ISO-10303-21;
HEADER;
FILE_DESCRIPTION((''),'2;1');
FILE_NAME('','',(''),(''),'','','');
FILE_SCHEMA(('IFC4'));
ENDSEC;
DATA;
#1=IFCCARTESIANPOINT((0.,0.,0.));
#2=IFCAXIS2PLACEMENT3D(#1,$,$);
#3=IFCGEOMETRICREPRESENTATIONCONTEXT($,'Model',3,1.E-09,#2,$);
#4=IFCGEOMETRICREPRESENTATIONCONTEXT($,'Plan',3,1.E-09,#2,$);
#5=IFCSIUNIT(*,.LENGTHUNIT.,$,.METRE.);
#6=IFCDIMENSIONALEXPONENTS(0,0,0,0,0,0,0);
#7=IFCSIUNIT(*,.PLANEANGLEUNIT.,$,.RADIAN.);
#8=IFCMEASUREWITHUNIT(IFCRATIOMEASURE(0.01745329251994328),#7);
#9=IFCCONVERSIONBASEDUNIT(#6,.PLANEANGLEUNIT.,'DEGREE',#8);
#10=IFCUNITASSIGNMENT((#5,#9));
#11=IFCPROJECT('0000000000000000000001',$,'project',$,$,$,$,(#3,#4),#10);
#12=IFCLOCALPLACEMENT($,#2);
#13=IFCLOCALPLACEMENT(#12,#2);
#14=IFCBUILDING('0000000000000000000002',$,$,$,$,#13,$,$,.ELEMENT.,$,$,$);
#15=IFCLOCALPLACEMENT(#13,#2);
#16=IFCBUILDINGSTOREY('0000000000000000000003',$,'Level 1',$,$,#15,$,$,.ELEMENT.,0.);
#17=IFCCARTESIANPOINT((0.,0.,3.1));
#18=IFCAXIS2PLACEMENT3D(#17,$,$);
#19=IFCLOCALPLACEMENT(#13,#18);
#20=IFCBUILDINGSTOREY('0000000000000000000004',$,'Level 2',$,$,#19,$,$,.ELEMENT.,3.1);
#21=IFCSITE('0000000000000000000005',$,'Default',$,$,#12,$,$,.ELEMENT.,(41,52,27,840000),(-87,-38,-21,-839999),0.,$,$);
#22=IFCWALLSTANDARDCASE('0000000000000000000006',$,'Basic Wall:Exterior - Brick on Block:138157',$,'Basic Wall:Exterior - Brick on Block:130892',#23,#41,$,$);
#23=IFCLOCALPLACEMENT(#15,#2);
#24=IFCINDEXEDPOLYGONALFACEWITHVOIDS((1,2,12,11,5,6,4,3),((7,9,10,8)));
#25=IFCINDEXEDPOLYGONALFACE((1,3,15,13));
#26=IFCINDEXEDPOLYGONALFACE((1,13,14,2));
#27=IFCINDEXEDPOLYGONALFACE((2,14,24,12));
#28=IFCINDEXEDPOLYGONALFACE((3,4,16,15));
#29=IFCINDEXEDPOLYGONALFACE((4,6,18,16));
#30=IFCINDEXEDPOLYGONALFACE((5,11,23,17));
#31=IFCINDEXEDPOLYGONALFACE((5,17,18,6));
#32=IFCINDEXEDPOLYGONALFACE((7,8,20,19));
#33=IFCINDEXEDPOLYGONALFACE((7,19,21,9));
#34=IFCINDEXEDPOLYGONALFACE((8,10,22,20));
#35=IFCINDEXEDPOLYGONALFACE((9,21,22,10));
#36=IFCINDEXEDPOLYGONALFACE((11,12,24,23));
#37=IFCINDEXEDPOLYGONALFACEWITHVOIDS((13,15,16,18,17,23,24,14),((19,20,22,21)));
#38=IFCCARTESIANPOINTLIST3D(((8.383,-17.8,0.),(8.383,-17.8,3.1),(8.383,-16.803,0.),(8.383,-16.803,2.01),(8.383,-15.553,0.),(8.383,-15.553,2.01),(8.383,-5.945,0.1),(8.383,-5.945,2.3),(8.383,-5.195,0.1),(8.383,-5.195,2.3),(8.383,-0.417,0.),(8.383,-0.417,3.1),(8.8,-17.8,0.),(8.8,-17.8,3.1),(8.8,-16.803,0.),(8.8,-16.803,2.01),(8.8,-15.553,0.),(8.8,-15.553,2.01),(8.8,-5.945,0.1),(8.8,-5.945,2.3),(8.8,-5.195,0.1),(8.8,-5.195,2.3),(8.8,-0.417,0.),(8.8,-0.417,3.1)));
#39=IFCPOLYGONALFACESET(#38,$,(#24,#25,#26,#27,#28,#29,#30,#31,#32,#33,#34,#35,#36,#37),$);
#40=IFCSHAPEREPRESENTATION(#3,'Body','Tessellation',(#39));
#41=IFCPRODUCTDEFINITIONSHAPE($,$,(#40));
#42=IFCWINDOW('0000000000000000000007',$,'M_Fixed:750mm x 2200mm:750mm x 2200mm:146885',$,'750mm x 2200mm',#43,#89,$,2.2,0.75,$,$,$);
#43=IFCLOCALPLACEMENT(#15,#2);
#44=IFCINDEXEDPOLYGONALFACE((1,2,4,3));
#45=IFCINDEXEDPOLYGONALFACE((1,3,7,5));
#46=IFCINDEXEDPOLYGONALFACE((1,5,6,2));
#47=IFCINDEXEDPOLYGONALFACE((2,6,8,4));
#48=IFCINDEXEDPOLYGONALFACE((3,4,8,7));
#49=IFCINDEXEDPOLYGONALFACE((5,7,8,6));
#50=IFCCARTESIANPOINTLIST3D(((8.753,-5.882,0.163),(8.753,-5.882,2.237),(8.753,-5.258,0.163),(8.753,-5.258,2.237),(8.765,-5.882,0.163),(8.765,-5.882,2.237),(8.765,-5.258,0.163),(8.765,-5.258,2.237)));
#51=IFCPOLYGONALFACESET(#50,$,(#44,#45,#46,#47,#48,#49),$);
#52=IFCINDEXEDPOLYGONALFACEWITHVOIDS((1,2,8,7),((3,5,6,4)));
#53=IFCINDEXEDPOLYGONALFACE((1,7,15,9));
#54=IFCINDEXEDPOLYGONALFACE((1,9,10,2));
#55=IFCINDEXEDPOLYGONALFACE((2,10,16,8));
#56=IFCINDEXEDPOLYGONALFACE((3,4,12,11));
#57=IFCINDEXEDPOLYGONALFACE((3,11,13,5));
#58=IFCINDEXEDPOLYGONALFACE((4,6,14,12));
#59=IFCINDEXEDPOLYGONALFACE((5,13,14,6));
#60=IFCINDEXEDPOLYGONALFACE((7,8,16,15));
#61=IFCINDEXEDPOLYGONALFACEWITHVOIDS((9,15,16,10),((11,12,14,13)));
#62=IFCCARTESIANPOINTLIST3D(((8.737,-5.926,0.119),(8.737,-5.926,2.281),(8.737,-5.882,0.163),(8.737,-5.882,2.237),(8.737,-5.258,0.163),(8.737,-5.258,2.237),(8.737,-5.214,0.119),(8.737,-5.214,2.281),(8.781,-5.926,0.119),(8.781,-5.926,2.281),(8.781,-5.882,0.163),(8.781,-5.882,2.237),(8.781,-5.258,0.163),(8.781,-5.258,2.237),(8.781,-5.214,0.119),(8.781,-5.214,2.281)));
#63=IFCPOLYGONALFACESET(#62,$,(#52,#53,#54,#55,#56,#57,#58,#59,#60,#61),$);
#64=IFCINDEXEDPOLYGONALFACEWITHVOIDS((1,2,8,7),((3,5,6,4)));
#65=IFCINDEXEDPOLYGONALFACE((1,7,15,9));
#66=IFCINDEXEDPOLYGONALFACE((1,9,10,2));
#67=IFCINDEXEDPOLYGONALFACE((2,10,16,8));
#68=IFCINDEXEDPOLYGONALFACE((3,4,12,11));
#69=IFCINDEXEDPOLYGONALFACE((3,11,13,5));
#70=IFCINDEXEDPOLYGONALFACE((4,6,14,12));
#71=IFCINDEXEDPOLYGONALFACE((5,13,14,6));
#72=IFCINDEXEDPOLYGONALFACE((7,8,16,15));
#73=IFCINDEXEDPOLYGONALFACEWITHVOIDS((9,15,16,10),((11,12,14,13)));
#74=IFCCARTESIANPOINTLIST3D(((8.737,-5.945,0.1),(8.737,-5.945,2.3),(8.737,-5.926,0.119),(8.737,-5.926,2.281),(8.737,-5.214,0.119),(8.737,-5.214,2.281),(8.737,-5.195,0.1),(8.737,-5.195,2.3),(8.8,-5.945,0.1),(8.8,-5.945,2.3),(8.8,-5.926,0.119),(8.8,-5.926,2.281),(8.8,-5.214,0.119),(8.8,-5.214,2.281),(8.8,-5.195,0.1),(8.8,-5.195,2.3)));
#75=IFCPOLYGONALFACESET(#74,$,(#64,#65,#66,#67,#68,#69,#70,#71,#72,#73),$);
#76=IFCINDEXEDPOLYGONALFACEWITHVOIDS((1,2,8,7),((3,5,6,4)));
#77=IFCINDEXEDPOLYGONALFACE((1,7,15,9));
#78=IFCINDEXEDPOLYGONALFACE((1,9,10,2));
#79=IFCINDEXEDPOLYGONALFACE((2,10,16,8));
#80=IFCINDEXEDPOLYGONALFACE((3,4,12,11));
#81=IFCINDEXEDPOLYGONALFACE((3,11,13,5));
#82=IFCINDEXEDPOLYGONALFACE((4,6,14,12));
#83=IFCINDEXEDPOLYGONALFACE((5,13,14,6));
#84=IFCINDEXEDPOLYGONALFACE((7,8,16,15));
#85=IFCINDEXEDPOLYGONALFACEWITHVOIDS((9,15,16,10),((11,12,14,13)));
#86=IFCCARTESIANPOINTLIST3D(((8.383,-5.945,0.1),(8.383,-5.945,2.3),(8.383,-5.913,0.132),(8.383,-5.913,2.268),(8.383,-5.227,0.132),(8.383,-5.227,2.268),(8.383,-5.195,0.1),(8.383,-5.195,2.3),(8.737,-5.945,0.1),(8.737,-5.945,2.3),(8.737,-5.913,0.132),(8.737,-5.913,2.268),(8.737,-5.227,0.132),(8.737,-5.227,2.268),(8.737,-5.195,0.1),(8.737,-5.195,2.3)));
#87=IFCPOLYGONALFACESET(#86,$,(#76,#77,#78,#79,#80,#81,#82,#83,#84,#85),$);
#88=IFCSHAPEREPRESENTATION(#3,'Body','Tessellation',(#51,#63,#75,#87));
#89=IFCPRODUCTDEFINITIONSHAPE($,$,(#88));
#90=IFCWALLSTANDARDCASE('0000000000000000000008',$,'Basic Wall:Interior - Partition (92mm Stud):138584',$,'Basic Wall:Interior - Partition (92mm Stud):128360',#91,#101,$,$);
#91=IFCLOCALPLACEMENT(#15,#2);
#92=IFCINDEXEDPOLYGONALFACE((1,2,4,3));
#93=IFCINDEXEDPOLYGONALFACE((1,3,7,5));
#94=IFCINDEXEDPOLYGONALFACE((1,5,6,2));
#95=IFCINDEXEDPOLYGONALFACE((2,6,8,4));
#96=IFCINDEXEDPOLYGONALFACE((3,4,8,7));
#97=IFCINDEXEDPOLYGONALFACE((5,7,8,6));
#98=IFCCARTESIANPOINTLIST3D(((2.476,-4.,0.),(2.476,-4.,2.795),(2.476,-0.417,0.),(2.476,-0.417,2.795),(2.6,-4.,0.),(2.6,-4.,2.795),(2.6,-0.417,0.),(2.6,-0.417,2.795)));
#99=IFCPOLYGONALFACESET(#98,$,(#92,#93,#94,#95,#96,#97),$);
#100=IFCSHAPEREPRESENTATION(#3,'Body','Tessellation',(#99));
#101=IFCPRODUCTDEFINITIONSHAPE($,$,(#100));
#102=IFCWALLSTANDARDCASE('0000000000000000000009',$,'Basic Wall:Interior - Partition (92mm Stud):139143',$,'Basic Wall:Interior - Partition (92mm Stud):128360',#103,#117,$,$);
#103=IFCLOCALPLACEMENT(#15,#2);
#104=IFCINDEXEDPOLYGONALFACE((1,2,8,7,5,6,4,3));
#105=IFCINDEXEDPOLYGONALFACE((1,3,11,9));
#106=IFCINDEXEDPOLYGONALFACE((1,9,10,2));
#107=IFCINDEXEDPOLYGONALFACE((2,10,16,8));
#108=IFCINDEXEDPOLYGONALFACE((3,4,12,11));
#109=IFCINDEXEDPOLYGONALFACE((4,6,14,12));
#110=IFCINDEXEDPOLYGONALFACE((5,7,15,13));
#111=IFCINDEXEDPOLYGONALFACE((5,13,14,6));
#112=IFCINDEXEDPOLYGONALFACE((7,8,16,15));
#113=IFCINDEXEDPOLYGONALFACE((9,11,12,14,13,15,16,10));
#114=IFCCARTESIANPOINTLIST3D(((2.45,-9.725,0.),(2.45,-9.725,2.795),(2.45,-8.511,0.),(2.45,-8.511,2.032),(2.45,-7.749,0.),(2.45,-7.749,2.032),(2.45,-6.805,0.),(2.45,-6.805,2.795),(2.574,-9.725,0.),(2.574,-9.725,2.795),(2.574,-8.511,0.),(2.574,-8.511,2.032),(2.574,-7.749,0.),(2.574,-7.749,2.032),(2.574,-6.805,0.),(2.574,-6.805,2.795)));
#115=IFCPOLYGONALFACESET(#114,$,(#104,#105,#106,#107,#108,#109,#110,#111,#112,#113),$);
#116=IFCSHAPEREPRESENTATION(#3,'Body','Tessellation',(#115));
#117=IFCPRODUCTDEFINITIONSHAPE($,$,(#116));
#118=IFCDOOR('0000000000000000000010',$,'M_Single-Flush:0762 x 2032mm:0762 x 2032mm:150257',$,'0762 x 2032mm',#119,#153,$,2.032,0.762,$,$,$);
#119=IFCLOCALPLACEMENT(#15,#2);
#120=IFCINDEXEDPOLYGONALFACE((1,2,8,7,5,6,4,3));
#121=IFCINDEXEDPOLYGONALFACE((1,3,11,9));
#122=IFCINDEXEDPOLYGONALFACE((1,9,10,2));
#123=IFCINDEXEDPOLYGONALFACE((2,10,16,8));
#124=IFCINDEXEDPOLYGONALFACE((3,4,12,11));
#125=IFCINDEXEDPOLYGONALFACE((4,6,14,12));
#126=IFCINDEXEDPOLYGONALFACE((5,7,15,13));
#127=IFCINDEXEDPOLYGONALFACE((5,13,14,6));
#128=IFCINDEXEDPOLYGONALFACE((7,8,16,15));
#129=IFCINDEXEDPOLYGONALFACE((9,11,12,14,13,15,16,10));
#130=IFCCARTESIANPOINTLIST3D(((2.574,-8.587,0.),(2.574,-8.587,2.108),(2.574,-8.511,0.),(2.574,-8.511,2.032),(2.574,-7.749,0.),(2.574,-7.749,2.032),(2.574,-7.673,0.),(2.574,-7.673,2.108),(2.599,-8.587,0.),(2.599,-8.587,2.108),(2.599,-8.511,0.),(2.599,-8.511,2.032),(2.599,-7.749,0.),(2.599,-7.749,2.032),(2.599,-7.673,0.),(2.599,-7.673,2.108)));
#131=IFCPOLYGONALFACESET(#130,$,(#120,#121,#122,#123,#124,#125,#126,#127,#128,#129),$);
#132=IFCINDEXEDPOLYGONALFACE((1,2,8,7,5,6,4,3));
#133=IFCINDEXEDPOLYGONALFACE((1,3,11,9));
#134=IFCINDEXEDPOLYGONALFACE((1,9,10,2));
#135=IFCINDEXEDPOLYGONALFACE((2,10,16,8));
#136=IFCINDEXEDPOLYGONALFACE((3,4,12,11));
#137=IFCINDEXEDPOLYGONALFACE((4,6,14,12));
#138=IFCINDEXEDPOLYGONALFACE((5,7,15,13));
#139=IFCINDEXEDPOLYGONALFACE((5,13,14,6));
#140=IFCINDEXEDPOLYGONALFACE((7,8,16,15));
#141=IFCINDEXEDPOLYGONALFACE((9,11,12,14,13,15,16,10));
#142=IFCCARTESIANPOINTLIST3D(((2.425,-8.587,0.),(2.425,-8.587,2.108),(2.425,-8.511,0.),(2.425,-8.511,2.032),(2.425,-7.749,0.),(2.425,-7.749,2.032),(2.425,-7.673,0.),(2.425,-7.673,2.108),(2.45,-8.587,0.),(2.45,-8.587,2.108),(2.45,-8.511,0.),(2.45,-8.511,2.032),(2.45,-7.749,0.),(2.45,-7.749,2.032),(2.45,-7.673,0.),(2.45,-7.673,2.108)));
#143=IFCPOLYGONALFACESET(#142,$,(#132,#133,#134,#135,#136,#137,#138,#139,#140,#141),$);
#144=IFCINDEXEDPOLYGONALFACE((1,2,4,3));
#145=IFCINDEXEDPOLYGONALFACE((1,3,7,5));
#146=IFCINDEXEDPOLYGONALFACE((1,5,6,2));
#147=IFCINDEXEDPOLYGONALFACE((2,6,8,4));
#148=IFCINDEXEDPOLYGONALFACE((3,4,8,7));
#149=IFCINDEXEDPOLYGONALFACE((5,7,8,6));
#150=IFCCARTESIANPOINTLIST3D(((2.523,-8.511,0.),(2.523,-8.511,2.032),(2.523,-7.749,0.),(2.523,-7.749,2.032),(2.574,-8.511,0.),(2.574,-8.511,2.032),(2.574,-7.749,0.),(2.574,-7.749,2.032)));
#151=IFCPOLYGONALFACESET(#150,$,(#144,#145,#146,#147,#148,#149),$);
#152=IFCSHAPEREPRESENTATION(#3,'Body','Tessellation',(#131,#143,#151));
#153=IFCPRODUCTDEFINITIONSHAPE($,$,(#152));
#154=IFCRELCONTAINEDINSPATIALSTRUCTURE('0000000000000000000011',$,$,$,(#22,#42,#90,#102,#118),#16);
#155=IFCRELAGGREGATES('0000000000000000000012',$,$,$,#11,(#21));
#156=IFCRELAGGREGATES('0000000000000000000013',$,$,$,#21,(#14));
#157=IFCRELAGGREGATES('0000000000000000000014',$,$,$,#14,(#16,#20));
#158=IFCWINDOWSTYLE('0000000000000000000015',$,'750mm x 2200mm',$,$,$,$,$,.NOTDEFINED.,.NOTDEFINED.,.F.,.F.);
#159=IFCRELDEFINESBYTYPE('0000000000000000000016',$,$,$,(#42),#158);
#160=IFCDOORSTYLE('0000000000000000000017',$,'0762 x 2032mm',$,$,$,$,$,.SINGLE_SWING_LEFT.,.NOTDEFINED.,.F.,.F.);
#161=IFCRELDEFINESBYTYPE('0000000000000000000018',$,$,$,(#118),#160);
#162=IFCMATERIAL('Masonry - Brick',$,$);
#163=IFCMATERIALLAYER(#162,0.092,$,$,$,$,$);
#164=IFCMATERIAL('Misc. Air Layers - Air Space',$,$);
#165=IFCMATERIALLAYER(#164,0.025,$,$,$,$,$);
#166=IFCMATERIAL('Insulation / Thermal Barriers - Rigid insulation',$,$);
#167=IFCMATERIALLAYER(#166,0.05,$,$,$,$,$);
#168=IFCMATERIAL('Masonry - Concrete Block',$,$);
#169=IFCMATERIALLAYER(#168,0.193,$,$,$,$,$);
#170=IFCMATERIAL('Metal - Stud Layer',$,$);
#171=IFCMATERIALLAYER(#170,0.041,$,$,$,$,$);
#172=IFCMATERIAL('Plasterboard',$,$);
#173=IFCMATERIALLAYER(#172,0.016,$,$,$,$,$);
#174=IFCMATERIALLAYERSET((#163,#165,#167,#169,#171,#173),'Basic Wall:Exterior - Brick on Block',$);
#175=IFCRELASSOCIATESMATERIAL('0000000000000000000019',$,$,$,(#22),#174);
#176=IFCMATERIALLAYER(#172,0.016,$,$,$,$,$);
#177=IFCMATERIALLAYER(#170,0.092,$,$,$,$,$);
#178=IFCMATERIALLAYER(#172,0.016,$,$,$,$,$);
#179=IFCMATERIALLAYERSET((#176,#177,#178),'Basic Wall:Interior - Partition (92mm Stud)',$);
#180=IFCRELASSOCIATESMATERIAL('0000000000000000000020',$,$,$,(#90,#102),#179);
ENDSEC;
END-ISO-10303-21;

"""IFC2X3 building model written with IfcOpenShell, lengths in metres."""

from ifc_helpers import new_model, entity, si_unit, converted_unit, frame, frame_2d, origin, origin_2d_with_axis, place, context, project, spatial, polyline, rectangle, outline, extrude, source, transform, mapped, material, layer, layer_set, layer_usage, type_object, type_shapes, element, fill, save


model = new_model("IFC2X3")

# Units and contexts
model_context_1 = context("Model", 3, precision=1e-09, world=origin())
plan_context = context("Plan", 3, precision=1e-09, world=origin())
ifc_project = project(units=[si_unit("LENGTHUNIT", "METRE"), converted_unit("PLANEANGLEUNIT", "DEGREE", entity("IfcRatioMeasure", 0.01745329251994328), si_unit("PLANEANGLEUNIT", "RADIAN"), dimensions=[0, 0, 0, 0, 0, 0, 0])], contexts=[model_context_1, plan_context])

# Site, building, storey
site_placement = place(None, origin())
site = spatial("IfcSite", under=ifc_project, at=site_placement, Name="Default", CompositionType="ELEMENT", RefLatitude=(41, 52, 27, 840000), RefLongitude=(-87, -38, -21, -839999), RefElevation=0.0)
building_placement = place(site_placement, origin())
building = spatial("IfcBuilding", under=site, at=building_placement, CompositionType="ELEMENT")
storey_1_placement = place(building_placement, origin())
storey_1 = spatial("IfcBuildingStorey", under=building, at=storey_1_placement, Name="Level 1", CompositionType="ELEMENT", Elevation=0.0)

# Shared definitions
ifc_material_1 = material(Name="Masonry - Brick")
ifc_layer_1 = layer(ifc_material_1, 0.092)
ifc_material_2 = material(Name="Misc. Air Layers - Air Space")
ifc_layer_2 = layer(ifc_material_2, 0.025)
ifc_material_3 = material(Name="Insulation / Thermal Barriers - Rigid insulation")
ifc_layer_3 = layer(ifc_material_3, 0.05)
ifc_material_4 = material(Name="Masonry - Concrete Block")
ifc_layer_4 = layer(ifc_material_4, 0.193)
ifc_material_5 = material(Name="Metal - Stud Layer")
ifc_layer_5 = layer(ifc_material_5, 0.041)
ifc_material_6 = material(Name="Plasterboard")
ifc_layer_6 = layer(ifc_material_6, 0.016)
ifc_layer_set_1 = layer_set([ifc_layer_1, ifc_layer_2, ifc_layer_3, ifc_layer_4, ifc_layer_5, ifc_layer_6], Name="Basic Wall:Exterior - Brick on Block")

# Wall, openings, window
ifc_layer_usage_1 = layer_usage(ifc_layer_set_1, "AXIS2", "NEGATIVE", 0.2085)
wall_1_placement = place(storey_1_placement, frame((8.5915, -0.417, 0.0), z_axis=(0.0, 0.0, 1.0), x_axis=(0.0, -1.0, 0.0)))
wall_1 = element("IfcWallStandardCase", 1, at=wall_1_placement, inside=storey_1, material=ifc_layer_usage_1, Name="Basic Wall:Exterior - Brick on Block:138157", ObjectType="Basic Wall:Exterior - Brick on Block:130892", context=model_context_1, shape_type="SweptSolid", body=[
    extrude(rectangle(XDim=17.383, YDim=0.417, at=frame_2d((8.6915, 0.0), x_axis=(-1.0, 0.0))), origin(), (0.0, 0.0, 1.0), 3.1),
])
opening_1_placement = place(wall_1_placement, frame((15.136, -0.2085, 0.0)))
element("IfcOpeningElement", 2, at=opening_1_placement, cuts=wall_1, ObjectType="Opening", context=model_context_1, shape_type="SweptSolid", body=[
    extrude(rectangle(XDim=1.25, YDim=2.01, at=frame_2d((1.005, 0.625), x_axis=(0.0, 1.0))), frame((0.0, 0.0, 0.0), z_axis=(0.0, 1.0, 0.0), x_axis=(0.0, 0.0, 1.0)), (0.0, 0.0, 1.0), 0.417),
])
opening_2_placement = place(wall_1_placement, frame((4.778, -0.2085, 0.1)))
opening_2 = element("IfcOpeningElement", 3, at=opening_2_placement, cuts=wall_1, ObjectType="Opening", context=model_context_1, shape_type="SweptSolid", body=[
    extrude(rectangle(XDim=2.2, YDim=0.75, at=frame_2d((1.1, 0.375), x_axis=(1.0, 0.0))), frame((0.0, 0.0, 0.0), z_axis=(0.0, 1.0, 0.0), x_axis=(0.0, 0.0, 1.0)), (0.0, 0.0, 1.0), 0.417),
])
window_style_1 = type_object("IfcWindowStyle", Name="750mm x 2200mm", ConstructionType="NOTDEFINED", OperationType="NOTDEFINED", ParameterTakesPrecedence=False, Sizeable=False)
shared_shape_1 = source(origin(), model_context_1, "Body", "SweptSolid", [
    extrude(rectangle(XDim=0.012, YDim=0.624, at=origin_2d_with_axis()), frame((0.375, 0.376, 0.063), z_axis=(0.0, 0.0, 1.0), x_axis=(0.0, -1.0, 0.0)), (0.0, 0.0, 1.0), 2.074),
    extrude(outline(polyline([(-0.356, -1.081), (0.356, -1.081), (0.356, 1.081), (-0.356, 1.081), (-0.356, -1.081)]), holes=[polyline([(-0.312, -1.037), (-0.312, 1.037), (0.312, 1.037), (0.312, -1.037), (-0.312, -1.037)])]), frame((0.375, 0.354, 1.1), z_axis=(0.0, 1.0, 0.0), x_axis=(1.0, 0.0, 0.0)), (0.0, 0.0, 1.0), 0.044),
    extrude(outline(polyline([(-0.375, -1.1), (0.375, -1.1), (0.375, 1.1), (-0.375, 1.1), (-0.375, -1.1)]), holes=[polyline([(-0.356, -1.081), (-0.356, 1.081), (0.356, 1.081), (0.356, -1.081), (-0.356, -1.081)])]), frame((0.375, 0.354, 1.1), z_axis=(0.0, 1.0, 0.0), x_axis=(1.0, 0.0, 0.0)), (0.0, 0.0, 1.0), 0.063),
    extrude(outline(polyline([(-0.375, -1.1), (0.375, -1.1), (0.375, 1.1), (-0.375, 1.1), (-0.375, -1.1)]), holes=[polyline([(-0.343, -1.068), (-0.343, 1.068), (0.343, 1.068), (0.343, -1.068), (-0.343, -1.068)])]), frame((0.375, 0.0, 1.1), z_axis=(0.0, 1.0, 0.0), x_axis=(1.0, 0.0, 0.0)), (0.0, 0.0, 1.0), 0.354),
])
type_shapes(window_style_1, [shared_shape_1])
window_1_placement = place(opening_2_placement, origin())
window_1 = element("IfcWindow", 4, at=window_1_placement, inside=storey_1, type_object=window_style_1, Name="M_Fixed:750mm x 2200mm:750mm x 2200mm:146885", ObjectType="750mm x 2200mm", OverallHeight=2.2, OverallWidth=0.75, context=model_context_1, shape_type="MappedRepresentation", body=[
    mapped(shared_shape_1, transform((0.0, 0.0, 0.0), scale=1.0)),
])
fill(opening_2, window_1)

# Wall
ifc_layer_7 = layer(ifc_material_6, 0.016)
ifc_layer_8 = layer(ifc_material_5, 0.092)
ifc_layer_9 = layer(ifc_material_6, 0.016)
ifc_layer_set_2 = layer_set([ifc_layer_7, ifc_layer_8, ifc_layer_9], Name="Basic Wall:Interior - Partition (92mm Stud)")
ifc_layer_usage_2 = layer_usage(ifc_layer_set_2, "AXIS2", "NEGATIVE", 0.062)
wall_2_placement = place(storey_1_placement, frame((2.538, -0.417, 0.0), z_axis=(0.0, 0.0, 1.0), x_axis=(0.0, -1.0, 0.0)))
element("IfcWallStandardCase", 5, at=wall_2_placement, inside=storey_1, material=ifc_layer_usage_2, Name="Basic Wall:Interior - Partition (92mm Stud):138584", ObjectType="Basic Wall:Interior - Partition (92mm Stud):128360", context=model_context_1, shape_type="SweptSolid", body=[
    extrude(rectangle(XDim=3.583, YDim=0.124, at=frame_2d((1.7915, 0.0), x_axis=(-1.0, 0.0))), origin(), (0.0, 0.0, 1.0), 2.795),
])

# Wall, opening, door
ifc_layer_usage_3 = layer_usage(ifc_layer_set_2, "AXIS2", "NEGATIVE", 0.062)
wall_3_placement = place(storey_1_placement, frame((2.512, -6.805, 0.0), z_axis=(0.0, 0.0, 1.0), x_axis=(0.0, -1.0, 0.0)))
wall_3 = element("IfcWallStandardCase", 6, at=wall_3_placement, inside=storey_1, material=ifc_layer_usage_3, Name="Basic Wall:Interior - Partition (92mm Stud):139143", ObjectType="Basic Wall:Interior - Partition (92mm Stud):128360", context=model_context_1, shape_type="SweptSolid", body=[
    extrude(rectangle(XDim=2.92, YDim=0.124, at=frame_2d((1.46, 0.0), x_axis=(-1.0, 0.0))), origin(), (0.0, 0.0, 1.0), 2.795),
])
opening_3_placement = place(wall_3_placement, frame((0.944, -0.062, 0.0)))
opening_3 = element("IfcOpeningElement", 7, at=opening_3_placement, cuts=wall_3, ObjectType="Opening", context=model_context_1, shape_type="SweptSolid", body=[
    extrude(rectangle(XDim=0.762, YDim=2.032, at=frame_2d((1.016, 0.381), x_axis=(0.0, -1.0))), frame((0.0, 0.0, 0.0), z_axis=(0.0, 1.0, 0.0), x_axis=(0.0, 0.0, 1.0)), (0.0, 0.0, 1.0), 0.124),
])
door_style_1 = type_object("IfcDoorStyle", Name="0762 x 2032mm", ConstructionType="NOTDEFINED", OperationType="SINGLE_SWING_LEFT", ParameterTakesPrecedence=False, Sizeable=False)
shared_shape_2 = source(origin(), model_context_1, "Body", "SweptSolid", [
    extrude(outline(polyline([(-0.457, -1.073), (0.457, -1.073), (0.457, 1.035), (0.381, 1.035), (0.381, -0.997), (-0.381, -0.997), (-0.381, 1.035), (-0.457, 1.035), (-0.457, -1.073)])), frame((0.381, 0.149, 1.035), z_axis=(0.0, -1.0, 0.0), x_axis=(-1.0, 0.0, 0.0)), (0.0, 0.0, 1.0), 0.025),
    extrude(outline(polyline([(-1.073, -0.457), (1.035, -0.457), (1.035, -0.381), (-0.997, -0.381), (-0.997, 0.381), (1.035, 0.381), (1.035, 0.457), (-1.073, 0.457), (-1.073, -0.457)])), frame((0.381, 0.0, 1.035), z_axis=(0.0, -1.0, 0.0), x_axis=(0.0, 0.0, -1.0)), (0.0, 0.0, 1.0), 0.025),
    extrude(rectangle(XDim=0.762, YDim=0.051, at=origin_2d_with_axis()), frame((0.381, 0.0985, 0.0)), (0.0, 0.0, 1.0), 2.032),
])
type_shapes(door_style_1, [shared_shape_2])
door_1_placement = place(opening_3_placement, origin())
door_1 = element("IfcDoor", 8, at=door_1_placement, inside=storey_1, type_object=door_style_1, Name="M_Single-Flush:0762 x 2032mm:0762 x 2032mm:150257", ObjectType="0762 x 2032mm", OverallHeight=2.032, OverallWidth=0.762, context=model_context_1, shape_type="MappedRepresentation", body=[
    mapped(shared_shape_2, transform((0.0, 0.0, 0.0), scale=1.0)),
])
fill(opening_3, door_1)

# Shared definitions
storey_2_placement = place(building_placement, frame((0.0, 0.0, 3.1)))
storey_2 = spatial("IfcBuildingStorey", under=building, at=storey_2_placement, Name="Level 2", CompositionType="ELEMENT", Elevation=3.1)

save(model, "model.ifc")
